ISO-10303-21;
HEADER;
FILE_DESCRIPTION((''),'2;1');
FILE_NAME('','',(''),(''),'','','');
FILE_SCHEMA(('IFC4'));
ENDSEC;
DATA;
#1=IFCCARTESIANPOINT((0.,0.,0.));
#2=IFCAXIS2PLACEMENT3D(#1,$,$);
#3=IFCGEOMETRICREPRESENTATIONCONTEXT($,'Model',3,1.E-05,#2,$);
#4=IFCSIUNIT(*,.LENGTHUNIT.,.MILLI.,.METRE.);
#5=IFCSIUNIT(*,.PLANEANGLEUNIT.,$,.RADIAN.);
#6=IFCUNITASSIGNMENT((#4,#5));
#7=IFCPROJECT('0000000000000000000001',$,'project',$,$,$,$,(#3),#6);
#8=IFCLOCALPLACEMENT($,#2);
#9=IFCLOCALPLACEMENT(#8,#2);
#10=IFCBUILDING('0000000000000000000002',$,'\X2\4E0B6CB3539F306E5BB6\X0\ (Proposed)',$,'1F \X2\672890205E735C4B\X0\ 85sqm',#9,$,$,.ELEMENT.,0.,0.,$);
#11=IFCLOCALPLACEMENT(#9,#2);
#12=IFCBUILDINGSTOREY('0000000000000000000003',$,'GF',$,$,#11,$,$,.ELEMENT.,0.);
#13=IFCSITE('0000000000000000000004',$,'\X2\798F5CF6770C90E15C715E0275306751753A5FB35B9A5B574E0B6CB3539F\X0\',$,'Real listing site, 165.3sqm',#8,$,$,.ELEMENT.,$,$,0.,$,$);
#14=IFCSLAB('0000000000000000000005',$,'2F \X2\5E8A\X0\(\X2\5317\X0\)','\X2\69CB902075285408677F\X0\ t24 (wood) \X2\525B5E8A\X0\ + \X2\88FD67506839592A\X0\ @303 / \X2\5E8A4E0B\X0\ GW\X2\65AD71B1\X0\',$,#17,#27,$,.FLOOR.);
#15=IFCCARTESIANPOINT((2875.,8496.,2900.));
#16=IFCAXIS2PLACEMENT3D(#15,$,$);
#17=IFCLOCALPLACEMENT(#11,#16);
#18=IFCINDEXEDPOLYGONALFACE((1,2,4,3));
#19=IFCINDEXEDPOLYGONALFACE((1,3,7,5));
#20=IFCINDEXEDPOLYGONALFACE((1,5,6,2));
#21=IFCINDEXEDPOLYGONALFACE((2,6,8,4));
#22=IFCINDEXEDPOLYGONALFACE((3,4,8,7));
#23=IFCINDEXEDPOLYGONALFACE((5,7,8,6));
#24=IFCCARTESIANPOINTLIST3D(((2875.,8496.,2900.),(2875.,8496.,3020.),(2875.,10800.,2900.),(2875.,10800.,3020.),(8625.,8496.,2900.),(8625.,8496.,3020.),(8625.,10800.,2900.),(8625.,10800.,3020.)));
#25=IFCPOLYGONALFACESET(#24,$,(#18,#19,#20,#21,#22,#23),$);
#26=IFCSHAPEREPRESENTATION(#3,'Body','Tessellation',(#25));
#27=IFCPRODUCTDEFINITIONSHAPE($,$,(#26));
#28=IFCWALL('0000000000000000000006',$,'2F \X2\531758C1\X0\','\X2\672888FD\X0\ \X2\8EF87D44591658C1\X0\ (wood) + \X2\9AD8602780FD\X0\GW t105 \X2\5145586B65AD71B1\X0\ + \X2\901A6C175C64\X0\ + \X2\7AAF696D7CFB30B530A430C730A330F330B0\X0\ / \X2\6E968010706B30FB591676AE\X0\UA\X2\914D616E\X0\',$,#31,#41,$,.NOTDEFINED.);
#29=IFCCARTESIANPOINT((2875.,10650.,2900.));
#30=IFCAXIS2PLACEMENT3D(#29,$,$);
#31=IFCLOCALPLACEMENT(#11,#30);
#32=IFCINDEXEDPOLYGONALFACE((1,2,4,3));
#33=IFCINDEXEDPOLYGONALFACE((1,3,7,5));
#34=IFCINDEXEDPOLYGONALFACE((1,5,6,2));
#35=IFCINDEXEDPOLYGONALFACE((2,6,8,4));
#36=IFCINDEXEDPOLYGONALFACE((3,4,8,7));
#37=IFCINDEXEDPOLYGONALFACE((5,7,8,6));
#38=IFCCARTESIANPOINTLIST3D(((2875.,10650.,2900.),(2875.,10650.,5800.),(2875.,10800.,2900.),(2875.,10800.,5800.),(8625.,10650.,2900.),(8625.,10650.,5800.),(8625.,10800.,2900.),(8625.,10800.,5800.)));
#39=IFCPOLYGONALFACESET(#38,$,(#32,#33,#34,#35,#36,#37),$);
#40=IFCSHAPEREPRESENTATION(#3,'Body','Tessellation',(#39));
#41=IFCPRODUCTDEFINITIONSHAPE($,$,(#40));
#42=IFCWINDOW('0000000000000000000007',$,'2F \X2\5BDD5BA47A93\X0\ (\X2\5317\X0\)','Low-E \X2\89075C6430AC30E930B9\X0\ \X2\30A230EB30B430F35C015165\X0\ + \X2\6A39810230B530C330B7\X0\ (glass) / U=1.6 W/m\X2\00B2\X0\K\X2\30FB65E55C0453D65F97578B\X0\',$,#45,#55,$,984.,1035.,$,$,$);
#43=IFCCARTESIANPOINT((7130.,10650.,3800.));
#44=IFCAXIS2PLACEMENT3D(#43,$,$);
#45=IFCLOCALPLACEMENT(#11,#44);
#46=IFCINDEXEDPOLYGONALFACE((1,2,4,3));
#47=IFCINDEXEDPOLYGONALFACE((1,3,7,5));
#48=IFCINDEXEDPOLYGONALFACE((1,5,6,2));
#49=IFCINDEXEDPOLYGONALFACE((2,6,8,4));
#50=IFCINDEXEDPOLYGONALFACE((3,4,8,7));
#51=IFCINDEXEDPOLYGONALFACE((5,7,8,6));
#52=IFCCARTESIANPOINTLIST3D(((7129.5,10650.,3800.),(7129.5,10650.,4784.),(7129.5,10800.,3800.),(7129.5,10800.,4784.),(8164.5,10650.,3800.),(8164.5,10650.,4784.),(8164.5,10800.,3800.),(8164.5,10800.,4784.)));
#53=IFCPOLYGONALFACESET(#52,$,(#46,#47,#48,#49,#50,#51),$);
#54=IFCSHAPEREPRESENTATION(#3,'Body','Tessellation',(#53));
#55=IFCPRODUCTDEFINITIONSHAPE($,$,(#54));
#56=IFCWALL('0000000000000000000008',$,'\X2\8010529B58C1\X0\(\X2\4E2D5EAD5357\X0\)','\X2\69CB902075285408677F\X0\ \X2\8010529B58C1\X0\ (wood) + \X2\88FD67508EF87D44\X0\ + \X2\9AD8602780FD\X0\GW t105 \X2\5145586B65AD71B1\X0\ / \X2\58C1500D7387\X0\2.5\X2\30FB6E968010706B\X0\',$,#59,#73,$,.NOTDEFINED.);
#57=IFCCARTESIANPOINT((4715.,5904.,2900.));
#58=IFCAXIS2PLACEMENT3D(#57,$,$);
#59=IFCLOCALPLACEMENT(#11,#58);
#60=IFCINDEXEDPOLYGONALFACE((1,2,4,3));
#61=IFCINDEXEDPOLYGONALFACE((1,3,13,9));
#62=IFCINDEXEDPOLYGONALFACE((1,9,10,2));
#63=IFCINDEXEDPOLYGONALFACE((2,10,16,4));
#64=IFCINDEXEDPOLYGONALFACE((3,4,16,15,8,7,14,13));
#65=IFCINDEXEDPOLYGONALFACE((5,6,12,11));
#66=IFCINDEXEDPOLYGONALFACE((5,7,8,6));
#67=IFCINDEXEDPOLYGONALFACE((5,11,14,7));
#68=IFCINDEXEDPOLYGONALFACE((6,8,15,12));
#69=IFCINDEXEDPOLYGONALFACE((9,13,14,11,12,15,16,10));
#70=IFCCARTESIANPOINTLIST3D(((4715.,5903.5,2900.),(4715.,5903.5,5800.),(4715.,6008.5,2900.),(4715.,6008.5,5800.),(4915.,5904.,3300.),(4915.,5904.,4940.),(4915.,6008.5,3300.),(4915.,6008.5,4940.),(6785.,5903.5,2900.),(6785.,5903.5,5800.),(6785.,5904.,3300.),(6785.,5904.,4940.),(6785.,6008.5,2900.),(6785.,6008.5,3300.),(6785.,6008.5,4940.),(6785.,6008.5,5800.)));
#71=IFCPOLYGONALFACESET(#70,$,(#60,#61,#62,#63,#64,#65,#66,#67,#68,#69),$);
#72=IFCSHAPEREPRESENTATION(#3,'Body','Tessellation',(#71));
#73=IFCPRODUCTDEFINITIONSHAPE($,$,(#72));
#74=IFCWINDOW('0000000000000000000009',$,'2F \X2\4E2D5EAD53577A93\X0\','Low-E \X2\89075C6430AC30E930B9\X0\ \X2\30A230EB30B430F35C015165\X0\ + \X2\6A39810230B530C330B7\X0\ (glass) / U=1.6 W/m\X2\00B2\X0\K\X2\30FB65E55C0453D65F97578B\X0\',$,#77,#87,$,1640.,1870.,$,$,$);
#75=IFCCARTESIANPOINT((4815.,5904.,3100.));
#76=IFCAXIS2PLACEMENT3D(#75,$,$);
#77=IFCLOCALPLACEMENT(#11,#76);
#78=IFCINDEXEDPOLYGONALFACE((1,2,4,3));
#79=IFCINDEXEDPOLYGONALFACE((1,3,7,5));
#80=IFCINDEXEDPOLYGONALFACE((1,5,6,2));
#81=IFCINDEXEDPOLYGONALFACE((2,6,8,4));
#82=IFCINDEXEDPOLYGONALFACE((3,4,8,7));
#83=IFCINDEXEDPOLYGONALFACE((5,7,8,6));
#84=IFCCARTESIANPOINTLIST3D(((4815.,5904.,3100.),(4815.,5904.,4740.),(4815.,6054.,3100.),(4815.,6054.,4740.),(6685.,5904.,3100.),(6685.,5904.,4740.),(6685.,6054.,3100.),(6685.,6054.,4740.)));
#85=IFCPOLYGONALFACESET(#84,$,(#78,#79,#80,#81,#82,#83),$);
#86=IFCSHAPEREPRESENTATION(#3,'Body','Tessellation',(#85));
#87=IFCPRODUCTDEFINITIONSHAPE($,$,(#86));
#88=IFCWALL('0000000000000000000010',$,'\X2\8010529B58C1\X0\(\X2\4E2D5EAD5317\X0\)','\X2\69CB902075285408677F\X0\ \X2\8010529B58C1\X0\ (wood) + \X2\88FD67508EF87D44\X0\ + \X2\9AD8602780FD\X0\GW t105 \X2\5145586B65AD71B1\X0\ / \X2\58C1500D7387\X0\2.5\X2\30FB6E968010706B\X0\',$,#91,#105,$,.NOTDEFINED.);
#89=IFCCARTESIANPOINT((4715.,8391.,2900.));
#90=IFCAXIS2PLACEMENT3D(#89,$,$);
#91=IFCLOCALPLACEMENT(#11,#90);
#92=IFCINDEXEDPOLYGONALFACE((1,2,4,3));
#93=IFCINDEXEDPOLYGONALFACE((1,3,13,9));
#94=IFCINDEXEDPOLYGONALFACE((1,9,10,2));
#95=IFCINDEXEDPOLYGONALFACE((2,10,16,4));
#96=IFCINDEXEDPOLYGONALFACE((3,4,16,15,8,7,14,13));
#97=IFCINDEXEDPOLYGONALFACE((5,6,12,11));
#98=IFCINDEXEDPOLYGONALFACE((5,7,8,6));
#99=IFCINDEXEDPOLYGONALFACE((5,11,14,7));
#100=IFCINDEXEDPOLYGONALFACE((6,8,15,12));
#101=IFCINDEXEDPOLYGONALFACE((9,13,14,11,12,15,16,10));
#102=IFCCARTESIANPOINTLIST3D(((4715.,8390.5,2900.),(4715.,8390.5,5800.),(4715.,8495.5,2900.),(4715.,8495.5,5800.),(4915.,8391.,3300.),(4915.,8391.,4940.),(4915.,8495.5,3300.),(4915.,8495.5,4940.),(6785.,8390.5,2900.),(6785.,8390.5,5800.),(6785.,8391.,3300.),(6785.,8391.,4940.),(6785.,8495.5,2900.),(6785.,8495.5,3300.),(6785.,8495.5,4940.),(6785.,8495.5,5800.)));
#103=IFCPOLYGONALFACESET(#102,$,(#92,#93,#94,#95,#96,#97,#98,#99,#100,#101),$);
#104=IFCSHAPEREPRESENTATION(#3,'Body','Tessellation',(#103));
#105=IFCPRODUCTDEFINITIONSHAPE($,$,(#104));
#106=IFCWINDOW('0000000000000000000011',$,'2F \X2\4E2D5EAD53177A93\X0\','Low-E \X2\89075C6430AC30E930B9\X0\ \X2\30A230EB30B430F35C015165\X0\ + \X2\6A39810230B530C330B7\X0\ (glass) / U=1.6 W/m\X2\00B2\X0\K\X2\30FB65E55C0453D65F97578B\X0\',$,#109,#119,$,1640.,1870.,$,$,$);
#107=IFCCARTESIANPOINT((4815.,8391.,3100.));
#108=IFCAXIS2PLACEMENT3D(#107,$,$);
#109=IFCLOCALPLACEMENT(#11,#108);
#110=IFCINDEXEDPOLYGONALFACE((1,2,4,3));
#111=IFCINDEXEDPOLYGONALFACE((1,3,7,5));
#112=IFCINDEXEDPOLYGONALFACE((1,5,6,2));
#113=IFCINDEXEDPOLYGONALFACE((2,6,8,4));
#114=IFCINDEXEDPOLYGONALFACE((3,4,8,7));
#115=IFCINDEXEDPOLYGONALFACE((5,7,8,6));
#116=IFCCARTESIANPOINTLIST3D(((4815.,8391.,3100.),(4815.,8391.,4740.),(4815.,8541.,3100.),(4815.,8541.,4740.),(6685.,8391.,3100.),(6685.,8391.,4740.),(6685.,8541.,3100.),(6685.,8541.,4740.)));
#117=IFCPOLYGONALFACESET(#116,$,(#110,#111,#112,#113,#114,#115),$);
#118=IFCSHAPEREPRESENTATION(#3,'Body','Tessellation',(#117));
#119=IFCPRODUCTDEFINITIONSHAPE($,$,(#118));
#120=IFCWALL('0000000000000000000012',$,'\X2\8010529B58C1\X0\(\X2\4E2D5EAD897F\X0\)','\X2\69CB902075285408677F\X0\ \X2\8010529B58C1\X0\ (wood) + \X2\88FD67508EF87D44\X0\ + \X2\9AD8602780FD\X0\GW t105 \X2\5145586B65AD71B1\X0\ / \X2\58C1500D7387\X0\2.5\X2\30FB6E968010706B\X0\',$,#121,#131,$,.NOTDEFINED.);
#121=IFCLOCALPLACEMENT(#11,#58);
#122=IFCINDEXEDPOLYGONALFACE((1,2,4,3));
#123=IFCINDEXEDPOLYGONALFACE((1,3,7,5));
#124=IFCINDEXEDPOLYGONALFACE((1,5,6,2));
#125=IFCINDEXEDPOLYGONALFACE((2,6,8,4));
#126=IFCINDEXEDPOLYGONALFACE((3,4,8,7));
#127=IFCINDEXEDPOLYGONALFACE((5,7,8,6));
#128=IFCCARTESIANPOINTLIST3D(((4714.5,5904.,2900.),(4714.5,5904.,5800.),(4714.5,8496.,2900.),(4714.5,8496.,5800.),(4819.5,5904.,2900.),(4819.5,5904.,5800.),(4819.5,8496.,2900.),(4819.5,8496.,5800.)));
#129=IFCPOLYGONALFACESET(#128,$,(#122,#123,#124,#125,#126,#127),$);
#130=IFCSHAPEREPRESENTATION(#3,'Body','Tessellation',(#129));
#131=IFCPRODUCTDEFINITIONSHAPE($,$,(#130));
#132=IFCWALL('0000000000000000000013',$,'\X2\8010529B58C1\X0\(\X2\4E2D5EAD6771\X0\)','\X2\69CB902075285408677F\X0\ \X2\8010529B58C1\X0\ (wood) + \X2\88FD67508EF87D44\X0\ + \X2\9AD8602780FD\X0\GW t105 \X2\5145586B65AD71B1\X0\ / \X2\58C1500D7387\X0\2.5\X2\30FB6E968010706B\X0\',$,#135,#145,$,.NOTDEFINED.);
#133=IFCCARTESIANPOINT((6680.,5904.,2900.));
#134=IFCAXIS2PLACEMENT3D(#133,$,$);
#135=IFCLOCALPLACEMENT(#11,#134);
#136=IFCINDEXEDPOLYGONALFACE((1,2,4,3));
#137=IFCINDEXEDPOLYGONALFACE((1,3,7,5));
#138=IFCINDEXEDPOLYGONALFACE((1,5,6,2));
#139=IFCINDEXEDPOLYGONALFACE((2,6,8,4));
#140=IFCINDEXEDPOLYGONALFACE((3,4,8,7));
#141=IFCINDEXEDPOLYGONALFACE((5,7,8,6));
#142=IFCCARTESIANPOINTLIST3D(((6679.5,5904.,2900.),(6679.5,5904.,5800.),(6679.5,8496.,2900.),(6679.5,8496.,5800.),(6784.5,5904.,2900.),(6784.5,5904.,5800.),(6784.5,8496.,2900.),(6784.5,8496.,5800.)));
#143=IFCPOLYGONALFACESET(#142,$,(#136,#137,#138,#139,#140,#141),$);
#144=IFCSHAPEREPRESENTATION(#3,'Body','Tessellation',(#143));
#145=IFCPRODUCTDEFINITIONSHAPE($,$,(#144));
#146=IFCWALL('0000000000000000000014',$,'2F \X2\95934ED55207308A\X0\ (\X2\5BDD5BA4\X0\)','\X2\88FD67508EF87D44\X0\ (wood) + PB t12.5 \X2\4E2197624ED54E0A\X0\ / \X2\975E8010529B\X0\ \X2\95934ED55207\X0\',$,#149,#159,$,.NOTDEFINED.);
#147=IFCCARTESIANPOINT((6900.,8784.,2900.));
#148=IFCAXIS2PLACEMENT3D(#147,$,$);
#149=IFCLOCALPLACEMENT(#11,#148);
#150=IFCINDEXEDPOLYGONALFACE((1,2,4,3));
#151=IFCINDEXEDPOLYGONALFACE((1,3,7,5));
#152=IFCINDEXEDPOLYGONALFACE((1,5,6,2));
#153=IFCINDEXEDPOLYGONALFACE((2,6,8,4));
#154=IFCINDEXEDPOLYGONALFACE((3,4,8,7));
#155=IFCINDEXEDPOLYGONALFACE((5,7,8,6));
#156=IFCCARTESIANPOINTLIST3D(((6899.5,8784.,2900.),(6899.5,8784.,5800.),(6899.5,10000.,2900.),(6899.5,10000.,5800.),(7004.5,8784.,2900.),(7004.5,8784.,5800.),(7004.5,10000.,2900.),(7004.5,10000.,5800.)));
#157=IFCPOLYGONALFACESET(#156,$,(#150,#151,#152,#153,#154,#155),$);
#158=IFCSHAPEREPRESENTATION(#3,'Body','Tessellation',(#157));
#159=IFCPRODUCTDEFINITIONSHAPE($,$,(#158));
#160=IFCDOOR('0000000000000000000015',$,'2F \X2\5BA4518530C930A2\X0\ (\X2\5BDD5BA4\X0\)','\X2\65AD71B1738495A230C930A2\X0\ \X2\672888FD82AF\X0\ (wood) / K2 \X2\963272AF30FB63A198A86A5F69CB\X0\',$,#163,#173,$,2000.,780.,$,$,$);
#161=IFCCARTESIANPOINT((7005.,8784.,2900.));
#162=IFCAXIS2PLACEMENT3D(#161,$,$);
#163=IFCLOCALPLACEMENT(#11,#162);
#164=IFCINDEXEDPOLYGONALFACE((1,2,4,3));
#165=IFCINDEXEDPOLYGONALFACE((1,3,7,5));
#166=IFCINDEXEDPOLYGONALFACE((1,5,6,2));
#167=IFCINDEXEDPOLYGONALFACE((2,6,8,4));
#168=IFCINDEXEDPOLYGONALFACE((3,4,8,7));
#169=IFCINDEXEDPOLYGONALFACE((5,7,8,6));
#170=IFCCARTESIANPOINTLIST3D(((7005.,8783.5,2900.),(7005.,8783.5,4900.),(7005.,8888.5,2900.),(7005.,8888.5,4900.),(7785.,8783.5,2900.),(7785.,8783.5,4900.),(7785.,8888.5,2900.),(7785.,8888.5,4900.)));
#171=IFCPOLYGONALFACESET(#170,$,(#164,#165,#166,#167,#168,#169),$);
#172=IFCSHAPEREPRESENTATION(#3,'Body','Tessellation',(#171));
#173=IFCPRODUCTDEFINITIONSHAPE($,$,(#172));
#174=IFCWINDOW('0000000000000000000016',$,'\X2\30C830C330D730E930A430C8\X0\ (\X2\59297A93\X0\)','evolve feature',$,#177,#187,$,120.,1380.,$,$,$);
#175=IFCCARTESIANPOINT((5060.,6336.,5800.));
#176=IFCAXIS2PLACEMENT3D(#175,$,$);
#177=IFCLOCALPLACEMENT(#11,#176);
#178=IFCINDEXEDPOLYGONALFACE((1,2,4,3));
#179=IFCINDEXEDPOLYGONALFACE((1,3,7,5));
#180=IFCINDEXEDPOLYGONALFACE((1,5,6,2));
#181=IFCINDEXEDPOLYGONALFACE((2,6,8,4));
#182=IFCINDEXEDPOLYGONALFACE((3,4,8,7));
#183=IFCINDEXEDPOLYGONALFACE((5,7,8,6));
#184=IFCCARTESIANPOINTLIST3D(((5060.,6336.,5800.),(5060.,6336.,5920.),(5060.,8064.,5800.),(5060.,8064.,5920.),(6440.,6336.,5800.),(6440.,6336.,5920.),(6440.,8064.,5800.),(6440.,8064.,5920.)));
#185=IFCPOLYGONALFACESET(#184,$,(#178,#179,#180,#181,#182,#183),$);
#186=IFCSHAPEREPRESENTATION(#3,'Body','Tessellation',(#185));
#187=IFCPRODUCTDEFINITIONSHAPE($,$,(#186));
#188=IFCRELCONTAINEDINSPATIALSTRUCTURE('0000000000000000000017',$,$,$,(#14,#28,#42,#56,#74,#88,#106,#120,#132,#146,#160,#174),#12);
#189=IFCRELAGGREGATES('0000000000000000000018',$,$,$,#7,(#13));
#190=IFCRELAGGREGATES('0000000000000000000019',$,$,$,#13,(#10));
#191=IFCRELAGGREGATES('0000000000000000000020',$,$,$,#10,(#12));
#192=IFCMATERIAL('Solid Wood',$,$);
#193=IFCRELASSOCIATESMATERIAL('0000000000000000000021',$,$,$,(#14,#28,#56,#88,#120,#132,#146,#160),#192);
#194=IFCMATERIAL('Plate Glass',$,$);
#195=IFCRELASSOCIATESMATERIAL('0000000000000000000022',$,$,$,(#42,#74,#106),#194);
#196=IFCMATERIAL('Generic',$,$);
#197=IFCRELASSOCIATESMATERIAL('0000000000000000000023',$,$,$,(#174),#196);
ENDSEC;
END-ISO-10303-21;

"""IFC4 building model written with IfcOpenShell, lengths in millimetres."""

from ifc_helpers import new_model, si_unit, frame, frame_2d, origin, place, context, project, spatial, rectangle, extrude, material, element, fill, save


model = new_model("IFC4")

# Units and contexts
model_context = context("Model", 3, precision=1e-05, world=origin())
ifc_project = project(units=[si_unit("LENGTHUNIT", "METRE", prefix="MILLI"), si_unit("PLANEANGLEUNIT", "RADIAN")], contexts=[model_context])

# Site, building, storey
site_placement = place(None, origin())
site = spatial("IfcSite", under=ifc_project, at=site_placement, Name="福島県郡山市田村町徳定字下河原", ObjectType="Real listing site, 165.3sqm", CompositionType="ELEMENT", RefElevation=0.0)
building_placement = place(site_placement, origin())
building = spatial("IfcBuilding", under=site, at=building_placement, Name="下河原の家 (Proposed)", ObjectType="1F 木造平屋 85sqm", CompositionType="ELEMENT", ElevationOfRefHeight=0.0, ElevationOfTerrain=0.0)
storey_placement = place(building_placement, origin())
storey = spatial("IfcBuildingStorey", under=building, at=storey_placement, Name="GF", CompositionType="ELEMENT", Elevation=0.0)

# Slab
ifc_material_1 = material(Name="Solid Wood")
slab_placement = place(storey_placement, frame((2875.0, 8496.0, 2900.0)))
element("IfcSlab", 1, at=slab_placement, inside=storey, material=ifc_material_1, Name="2F 床(北)", Description="構造用合板 t24 (wood) 剛床 + 製材根太 @303 / 床下 GW断熱", PredefinedType="FLOOR", context=model_context, shape_type="SweptSolid", body=[
    extrude(rectangle(XDim=5750.0, YDim=2304.0, at=frame_2d((2875.0, 1152.0))), frame((2875.0, 8496.0, 2900.0)), (0.0, 0.0, 1.0), 120.0),
])

# Walls, openings, windows
wall_1_placement = place(storey_placement, frame((2875.0, 10650.0, 2900.0)))
wall_1 = element("IfcWall", 2, at=wall_1_placement, inside=storey, material=ifc_material_1, Name="2F 北壁", Description="木製 軸組外壁 (wood) + 高性能GW t105 充填断熱 + 通気層 + 窯業系サイディング / 準耐火・外皮UA配慮", PredefinedType="NOTDEFINED", context=model_context, shape_type="SweptSolid", body=[
    extrude(rectangle(XDim=5750.0, YDim=150.0, at=frame_2d((2875.0, 75.0))), frame((2875.0, 10650.0, 2900.0)), (0.0, 0.0, 1.0), 2900.0),
])
opening_1_placement = place(storey_placement, frame((7130.0, 10650.0, 3800.0)))
opening_1 = element("IfcOpeningElement", 3, at=opening_1_placement, cuts=wall_1, PredefinedType="NOTDEFINED", context=model_context, shape_type="SweptSolid", body=[
    extrude(rectangle(XDim=1035.0, YDim=150.0, at=frame_2d((517.0, 75.0))), frame((7130.0, 10650.0, 3800.0)), (0.0, 0.0, 1.0), 984.0),
])
ifc_material_2 = material(Name="Plate Glass")
window_1_placement = place(storey_placement, frame((7130.0, 10650.0, 3800.0)))
window_1 = element("IfcWindow", 4, at=window_1_placement, inside=storey, material=ifc_material_2, Name="2F 寝室窓 (北)", Description="Low-E 複層ガラス アルゴン封入 + 樹脂サッシ (glass) / U=1.6 W/m²K・日射取得型", OverallHeight=984.0, OverallWidth=1035.0, context=model_context, shape_type="SweptSolid", body=[
    extrude(rectangle(XDim=1035.0, YDim=150.0, at=frame_2d((517.0, 75.0))), frame((7130.0, 10650.0, 3800.0)), (0.0, 0.0, 1.0), 984.0),
])
fill(opening_1, window_1)
wall_2_placement = place(storey_placement, frame((4715.0, 5904.0, 2900.0)))
wall_2 = element("IfcWall", 5, at=wall_2_placement, inside=storey, material=ifc_material_1, Name="耐力壁(中庭南)", Description="構造用合板 耐力壁 (wood) + 製材軸組 + 高性能GW t105 充填断熱 / 壁倍率2.5・準耐火", PredefinedType="NOTDEFINED", context=model_context, shape_type="SweptSolid", body=[
    extrude(rectangle(XDim=2070.0, YDim=105.0, at=frame_2d((1035.0, 52.0))), frame((4715.0, 5904.0, 2900.0)), (0.0, 0.0, 1.0), 2900.0),
])
opening_2_placement = place(storey_placement, frame((4815.0, 5904.0, 3100.0)))
opening_2 = element("IfcOpeningElement", 6, at=opening_2_placement, cuts=wall_2, PredefinedType="NOTDEFINED", context=model_context, shape_type="SweptSolid", body=[
    extrude(rectangle(XDim=1870.0, YDim=150.0, at=frame_2d((935.0, 75.0))), frame((4815.0, 5904.0, 3100.0)), (0.0, 0.0, 1.0), 1640.0),
])
window_2_placement = place(storey_placement, frame((4815.0, 5904.0, 3100.0)))
window_2 = element("IfcWindow", 7, at=window_2_placement, inside=storey, material=ifc_material_2, Name="2F 中庭南窓", Description="Low-E 複層ガラス アルゴン封入 + 樹脂サッシ (glass) / U=1.6 W/m²K・日射取得型", OverallHeight=1640.0, OverallWidth=1870.0, context=model_context, shape_type="SweptSolid", body=[
    extrude(rectangle(XDim=1870.0, YDim=150.0, at=frame_2d((935.0, 75.0))), frame((4815.0, 5904.0, 3100.0)), (0.0, 0.0, 1.0), 1640.0),
])
fill(opening_2, window_2)
wall_3_placement = place(storey_placement, frame((4715.0, 8391.0, 2900.0)))
wall_3 = element("IfcWall", 8, at=wall_3_placement, inside=storey, material=ifc_material_1, Name="耐力壁(中庭北)", Description="構造用合板 耐力壁 (wood) + 製材軸組 + 高性能GW t105 充填断熱 / 壁倍率2.5・準耐火", PredefinedType="NOTDEFINED", context=model_context, shape_type="SweptSolid", body=[
    extrude(rectangle(XDim=2070.0, YDim=105.0, at=frame_2d((1035.0, 52.0))), frame((4715.0, 8391.0, 2900.0)), (0.0, 0.0, 1.0), 2900.0),
])
opening_3_placement = place(storey_placement, frame((4815.0, 8391.0, 3100.0)))
opening_3 = element("IfcOpeningElement", 9, at=opening_3_placement, cuts=wall_3, PredefinedType="NOTDEFINED", context=model_context, shape_type="SweptSolid", body=[
    extrude(rectangle(XDim=1870.0, YDim=150.0, at=frame_2d((935.0, 75.0))), frame((4815.0, 8391.0, 3100.0)), (0.0, 0.0, 1.0), 1640.0),
])
window_3_placement = place(storey_placement, frame((4815.0, 8391.0, 3100.0)))
window_3 = element("IfcWindow", 10, at=window_3_placement, inside=storey, material=ifc_material_2, Name="2F 中庭北窓", Description="Low-E 複層ガラス アルゴン封入 + 樹脂サッシ (glass) / U=1.6 W/m²K・日射取得型", OverallHeight=1640.0, OverallWidth=1870.0, context=model_context, shape_type="SweptSolid", body=[
    extrude(rectangle(XDim=1870.0, YDim=150.0, at=frame_2d((935.0, 75.0))), frame((4815.0, 8391.0, 3100.0)), (0.0, 0.0, 1.0), 1640.0),
])
fill(opening_3, window_3)

# Walls
wall_4_placement = place(storey_placement, frame((4715.0, 5904.0, 2900.0)))
element("IfcWall", 11, at=wall_4_placement, inside=storey, material=ifc_material_1, Name="耐力壁(中庭西)", Description="構造用合板 耐力壁 (wood) + 製材軸組 + 高性能GW t105 充填断熱 / 壁倍率2.5・準耐火", PredefinedType="NOTDEFINED", context=model_context, shape_type="SweptSolid", body=[
    extrude(rectangle(XDim=105.0, YDim=2592.0, at=frame_2d((52.0, 1296.0))), frame((4715.0, 5904.0, 2900.0)), (0.0, 0.0, 1.0), 2900.0),
])
wall_5_placement = place(storey_placement, frame((6680.0, 5904.0, 2900.0)))
element("IfcWall", 12, at=wall_5_placement, inside=storey, material=ifc_material_1, Name="耐力壁(中庭東)", Description="構造用合板 耐力壁 (wood) + 製材軸組 + 高性能GW t105 充填断熱 / 壁倍率2.5・準耐火", PredefinedType="NOTDEFINED", context=model_context, shape_type="SweptSolid", body=[
    extrude(rectangle(XDim=105.0, YDim=2592.0, at=frame_2d((52.0, 1296.0))), frame((6680.0, 5904.0, 2900.0)), (0.0, 0.0, 1.0), 2900.0),
])
wall_6_placement = place(storey_placement, frame((6900.0, 8784.0, 2900.0)))
element("IfcWall", 13, at=wall_6_placement, inside=storey, material=ifc_material_1, Name="2F 間仕切り (寝室)", Description="製材軸組 (wood) + PB t12.5 両面仕上 / 非耐力 間仕切", PredefinedType="NOTDEFINED", context=model_context, shape_type="SweptSolid", body=[
    extrude(rectangle(XDim=105.0, YDim=1216.0, at=frame_2d((52.0, 608.0))), frame((6900.0, 8784.0, 2900.0)), (0.0, 0.0, 1.0), 2900.0),
])

# Door
door_placement = place(storey_placement, frame((7005.0, 8784.0, 2900.0)))
element("IfcDoor", 14, at=door_placement, inside=storey, material=ifc_material_1, Name="2F 室内ドア (寝室)", Description="断熱玄関ドア 木製芯 (wood) / K2 防犯・採風機構", OverallHeight=2000.0, OverallWidth=780.0, context=model_context, shape_type="SweptSolid", body=[
    extrude(rectangle(XDim=780.0, YDim=105.0, at=frame_2d((390.0, 52.0))), frame((7005.0, 8784.0, 2900.0)), (0.0, 0.0, 1.0), 2000.0),
])

# Window
ifc_material_3 = material(Name="Generic")
window_4_placement = place(storey_placement, frame((5060.0, 6336.0, 5800.0)))
element("IfcWindow", 15, at=window_4_placement, inside=storey, material=ifc_material_3, Name="トップライト (天窓)", Description="evolve feature", OverallHeight=120.0, OverallWidth=1380.0, context=model_context, shape_type="SweptSolid", body=[
    extrude(rectangle(XDim=1380.0, YDim=1728.0, at=frame_2d((690.0, 864.0))), frame((5060.0, 6336.0, 5800.0)), (0.0, 0.0, 1.0), 120.0),
])

save(model, "model.ifc")
